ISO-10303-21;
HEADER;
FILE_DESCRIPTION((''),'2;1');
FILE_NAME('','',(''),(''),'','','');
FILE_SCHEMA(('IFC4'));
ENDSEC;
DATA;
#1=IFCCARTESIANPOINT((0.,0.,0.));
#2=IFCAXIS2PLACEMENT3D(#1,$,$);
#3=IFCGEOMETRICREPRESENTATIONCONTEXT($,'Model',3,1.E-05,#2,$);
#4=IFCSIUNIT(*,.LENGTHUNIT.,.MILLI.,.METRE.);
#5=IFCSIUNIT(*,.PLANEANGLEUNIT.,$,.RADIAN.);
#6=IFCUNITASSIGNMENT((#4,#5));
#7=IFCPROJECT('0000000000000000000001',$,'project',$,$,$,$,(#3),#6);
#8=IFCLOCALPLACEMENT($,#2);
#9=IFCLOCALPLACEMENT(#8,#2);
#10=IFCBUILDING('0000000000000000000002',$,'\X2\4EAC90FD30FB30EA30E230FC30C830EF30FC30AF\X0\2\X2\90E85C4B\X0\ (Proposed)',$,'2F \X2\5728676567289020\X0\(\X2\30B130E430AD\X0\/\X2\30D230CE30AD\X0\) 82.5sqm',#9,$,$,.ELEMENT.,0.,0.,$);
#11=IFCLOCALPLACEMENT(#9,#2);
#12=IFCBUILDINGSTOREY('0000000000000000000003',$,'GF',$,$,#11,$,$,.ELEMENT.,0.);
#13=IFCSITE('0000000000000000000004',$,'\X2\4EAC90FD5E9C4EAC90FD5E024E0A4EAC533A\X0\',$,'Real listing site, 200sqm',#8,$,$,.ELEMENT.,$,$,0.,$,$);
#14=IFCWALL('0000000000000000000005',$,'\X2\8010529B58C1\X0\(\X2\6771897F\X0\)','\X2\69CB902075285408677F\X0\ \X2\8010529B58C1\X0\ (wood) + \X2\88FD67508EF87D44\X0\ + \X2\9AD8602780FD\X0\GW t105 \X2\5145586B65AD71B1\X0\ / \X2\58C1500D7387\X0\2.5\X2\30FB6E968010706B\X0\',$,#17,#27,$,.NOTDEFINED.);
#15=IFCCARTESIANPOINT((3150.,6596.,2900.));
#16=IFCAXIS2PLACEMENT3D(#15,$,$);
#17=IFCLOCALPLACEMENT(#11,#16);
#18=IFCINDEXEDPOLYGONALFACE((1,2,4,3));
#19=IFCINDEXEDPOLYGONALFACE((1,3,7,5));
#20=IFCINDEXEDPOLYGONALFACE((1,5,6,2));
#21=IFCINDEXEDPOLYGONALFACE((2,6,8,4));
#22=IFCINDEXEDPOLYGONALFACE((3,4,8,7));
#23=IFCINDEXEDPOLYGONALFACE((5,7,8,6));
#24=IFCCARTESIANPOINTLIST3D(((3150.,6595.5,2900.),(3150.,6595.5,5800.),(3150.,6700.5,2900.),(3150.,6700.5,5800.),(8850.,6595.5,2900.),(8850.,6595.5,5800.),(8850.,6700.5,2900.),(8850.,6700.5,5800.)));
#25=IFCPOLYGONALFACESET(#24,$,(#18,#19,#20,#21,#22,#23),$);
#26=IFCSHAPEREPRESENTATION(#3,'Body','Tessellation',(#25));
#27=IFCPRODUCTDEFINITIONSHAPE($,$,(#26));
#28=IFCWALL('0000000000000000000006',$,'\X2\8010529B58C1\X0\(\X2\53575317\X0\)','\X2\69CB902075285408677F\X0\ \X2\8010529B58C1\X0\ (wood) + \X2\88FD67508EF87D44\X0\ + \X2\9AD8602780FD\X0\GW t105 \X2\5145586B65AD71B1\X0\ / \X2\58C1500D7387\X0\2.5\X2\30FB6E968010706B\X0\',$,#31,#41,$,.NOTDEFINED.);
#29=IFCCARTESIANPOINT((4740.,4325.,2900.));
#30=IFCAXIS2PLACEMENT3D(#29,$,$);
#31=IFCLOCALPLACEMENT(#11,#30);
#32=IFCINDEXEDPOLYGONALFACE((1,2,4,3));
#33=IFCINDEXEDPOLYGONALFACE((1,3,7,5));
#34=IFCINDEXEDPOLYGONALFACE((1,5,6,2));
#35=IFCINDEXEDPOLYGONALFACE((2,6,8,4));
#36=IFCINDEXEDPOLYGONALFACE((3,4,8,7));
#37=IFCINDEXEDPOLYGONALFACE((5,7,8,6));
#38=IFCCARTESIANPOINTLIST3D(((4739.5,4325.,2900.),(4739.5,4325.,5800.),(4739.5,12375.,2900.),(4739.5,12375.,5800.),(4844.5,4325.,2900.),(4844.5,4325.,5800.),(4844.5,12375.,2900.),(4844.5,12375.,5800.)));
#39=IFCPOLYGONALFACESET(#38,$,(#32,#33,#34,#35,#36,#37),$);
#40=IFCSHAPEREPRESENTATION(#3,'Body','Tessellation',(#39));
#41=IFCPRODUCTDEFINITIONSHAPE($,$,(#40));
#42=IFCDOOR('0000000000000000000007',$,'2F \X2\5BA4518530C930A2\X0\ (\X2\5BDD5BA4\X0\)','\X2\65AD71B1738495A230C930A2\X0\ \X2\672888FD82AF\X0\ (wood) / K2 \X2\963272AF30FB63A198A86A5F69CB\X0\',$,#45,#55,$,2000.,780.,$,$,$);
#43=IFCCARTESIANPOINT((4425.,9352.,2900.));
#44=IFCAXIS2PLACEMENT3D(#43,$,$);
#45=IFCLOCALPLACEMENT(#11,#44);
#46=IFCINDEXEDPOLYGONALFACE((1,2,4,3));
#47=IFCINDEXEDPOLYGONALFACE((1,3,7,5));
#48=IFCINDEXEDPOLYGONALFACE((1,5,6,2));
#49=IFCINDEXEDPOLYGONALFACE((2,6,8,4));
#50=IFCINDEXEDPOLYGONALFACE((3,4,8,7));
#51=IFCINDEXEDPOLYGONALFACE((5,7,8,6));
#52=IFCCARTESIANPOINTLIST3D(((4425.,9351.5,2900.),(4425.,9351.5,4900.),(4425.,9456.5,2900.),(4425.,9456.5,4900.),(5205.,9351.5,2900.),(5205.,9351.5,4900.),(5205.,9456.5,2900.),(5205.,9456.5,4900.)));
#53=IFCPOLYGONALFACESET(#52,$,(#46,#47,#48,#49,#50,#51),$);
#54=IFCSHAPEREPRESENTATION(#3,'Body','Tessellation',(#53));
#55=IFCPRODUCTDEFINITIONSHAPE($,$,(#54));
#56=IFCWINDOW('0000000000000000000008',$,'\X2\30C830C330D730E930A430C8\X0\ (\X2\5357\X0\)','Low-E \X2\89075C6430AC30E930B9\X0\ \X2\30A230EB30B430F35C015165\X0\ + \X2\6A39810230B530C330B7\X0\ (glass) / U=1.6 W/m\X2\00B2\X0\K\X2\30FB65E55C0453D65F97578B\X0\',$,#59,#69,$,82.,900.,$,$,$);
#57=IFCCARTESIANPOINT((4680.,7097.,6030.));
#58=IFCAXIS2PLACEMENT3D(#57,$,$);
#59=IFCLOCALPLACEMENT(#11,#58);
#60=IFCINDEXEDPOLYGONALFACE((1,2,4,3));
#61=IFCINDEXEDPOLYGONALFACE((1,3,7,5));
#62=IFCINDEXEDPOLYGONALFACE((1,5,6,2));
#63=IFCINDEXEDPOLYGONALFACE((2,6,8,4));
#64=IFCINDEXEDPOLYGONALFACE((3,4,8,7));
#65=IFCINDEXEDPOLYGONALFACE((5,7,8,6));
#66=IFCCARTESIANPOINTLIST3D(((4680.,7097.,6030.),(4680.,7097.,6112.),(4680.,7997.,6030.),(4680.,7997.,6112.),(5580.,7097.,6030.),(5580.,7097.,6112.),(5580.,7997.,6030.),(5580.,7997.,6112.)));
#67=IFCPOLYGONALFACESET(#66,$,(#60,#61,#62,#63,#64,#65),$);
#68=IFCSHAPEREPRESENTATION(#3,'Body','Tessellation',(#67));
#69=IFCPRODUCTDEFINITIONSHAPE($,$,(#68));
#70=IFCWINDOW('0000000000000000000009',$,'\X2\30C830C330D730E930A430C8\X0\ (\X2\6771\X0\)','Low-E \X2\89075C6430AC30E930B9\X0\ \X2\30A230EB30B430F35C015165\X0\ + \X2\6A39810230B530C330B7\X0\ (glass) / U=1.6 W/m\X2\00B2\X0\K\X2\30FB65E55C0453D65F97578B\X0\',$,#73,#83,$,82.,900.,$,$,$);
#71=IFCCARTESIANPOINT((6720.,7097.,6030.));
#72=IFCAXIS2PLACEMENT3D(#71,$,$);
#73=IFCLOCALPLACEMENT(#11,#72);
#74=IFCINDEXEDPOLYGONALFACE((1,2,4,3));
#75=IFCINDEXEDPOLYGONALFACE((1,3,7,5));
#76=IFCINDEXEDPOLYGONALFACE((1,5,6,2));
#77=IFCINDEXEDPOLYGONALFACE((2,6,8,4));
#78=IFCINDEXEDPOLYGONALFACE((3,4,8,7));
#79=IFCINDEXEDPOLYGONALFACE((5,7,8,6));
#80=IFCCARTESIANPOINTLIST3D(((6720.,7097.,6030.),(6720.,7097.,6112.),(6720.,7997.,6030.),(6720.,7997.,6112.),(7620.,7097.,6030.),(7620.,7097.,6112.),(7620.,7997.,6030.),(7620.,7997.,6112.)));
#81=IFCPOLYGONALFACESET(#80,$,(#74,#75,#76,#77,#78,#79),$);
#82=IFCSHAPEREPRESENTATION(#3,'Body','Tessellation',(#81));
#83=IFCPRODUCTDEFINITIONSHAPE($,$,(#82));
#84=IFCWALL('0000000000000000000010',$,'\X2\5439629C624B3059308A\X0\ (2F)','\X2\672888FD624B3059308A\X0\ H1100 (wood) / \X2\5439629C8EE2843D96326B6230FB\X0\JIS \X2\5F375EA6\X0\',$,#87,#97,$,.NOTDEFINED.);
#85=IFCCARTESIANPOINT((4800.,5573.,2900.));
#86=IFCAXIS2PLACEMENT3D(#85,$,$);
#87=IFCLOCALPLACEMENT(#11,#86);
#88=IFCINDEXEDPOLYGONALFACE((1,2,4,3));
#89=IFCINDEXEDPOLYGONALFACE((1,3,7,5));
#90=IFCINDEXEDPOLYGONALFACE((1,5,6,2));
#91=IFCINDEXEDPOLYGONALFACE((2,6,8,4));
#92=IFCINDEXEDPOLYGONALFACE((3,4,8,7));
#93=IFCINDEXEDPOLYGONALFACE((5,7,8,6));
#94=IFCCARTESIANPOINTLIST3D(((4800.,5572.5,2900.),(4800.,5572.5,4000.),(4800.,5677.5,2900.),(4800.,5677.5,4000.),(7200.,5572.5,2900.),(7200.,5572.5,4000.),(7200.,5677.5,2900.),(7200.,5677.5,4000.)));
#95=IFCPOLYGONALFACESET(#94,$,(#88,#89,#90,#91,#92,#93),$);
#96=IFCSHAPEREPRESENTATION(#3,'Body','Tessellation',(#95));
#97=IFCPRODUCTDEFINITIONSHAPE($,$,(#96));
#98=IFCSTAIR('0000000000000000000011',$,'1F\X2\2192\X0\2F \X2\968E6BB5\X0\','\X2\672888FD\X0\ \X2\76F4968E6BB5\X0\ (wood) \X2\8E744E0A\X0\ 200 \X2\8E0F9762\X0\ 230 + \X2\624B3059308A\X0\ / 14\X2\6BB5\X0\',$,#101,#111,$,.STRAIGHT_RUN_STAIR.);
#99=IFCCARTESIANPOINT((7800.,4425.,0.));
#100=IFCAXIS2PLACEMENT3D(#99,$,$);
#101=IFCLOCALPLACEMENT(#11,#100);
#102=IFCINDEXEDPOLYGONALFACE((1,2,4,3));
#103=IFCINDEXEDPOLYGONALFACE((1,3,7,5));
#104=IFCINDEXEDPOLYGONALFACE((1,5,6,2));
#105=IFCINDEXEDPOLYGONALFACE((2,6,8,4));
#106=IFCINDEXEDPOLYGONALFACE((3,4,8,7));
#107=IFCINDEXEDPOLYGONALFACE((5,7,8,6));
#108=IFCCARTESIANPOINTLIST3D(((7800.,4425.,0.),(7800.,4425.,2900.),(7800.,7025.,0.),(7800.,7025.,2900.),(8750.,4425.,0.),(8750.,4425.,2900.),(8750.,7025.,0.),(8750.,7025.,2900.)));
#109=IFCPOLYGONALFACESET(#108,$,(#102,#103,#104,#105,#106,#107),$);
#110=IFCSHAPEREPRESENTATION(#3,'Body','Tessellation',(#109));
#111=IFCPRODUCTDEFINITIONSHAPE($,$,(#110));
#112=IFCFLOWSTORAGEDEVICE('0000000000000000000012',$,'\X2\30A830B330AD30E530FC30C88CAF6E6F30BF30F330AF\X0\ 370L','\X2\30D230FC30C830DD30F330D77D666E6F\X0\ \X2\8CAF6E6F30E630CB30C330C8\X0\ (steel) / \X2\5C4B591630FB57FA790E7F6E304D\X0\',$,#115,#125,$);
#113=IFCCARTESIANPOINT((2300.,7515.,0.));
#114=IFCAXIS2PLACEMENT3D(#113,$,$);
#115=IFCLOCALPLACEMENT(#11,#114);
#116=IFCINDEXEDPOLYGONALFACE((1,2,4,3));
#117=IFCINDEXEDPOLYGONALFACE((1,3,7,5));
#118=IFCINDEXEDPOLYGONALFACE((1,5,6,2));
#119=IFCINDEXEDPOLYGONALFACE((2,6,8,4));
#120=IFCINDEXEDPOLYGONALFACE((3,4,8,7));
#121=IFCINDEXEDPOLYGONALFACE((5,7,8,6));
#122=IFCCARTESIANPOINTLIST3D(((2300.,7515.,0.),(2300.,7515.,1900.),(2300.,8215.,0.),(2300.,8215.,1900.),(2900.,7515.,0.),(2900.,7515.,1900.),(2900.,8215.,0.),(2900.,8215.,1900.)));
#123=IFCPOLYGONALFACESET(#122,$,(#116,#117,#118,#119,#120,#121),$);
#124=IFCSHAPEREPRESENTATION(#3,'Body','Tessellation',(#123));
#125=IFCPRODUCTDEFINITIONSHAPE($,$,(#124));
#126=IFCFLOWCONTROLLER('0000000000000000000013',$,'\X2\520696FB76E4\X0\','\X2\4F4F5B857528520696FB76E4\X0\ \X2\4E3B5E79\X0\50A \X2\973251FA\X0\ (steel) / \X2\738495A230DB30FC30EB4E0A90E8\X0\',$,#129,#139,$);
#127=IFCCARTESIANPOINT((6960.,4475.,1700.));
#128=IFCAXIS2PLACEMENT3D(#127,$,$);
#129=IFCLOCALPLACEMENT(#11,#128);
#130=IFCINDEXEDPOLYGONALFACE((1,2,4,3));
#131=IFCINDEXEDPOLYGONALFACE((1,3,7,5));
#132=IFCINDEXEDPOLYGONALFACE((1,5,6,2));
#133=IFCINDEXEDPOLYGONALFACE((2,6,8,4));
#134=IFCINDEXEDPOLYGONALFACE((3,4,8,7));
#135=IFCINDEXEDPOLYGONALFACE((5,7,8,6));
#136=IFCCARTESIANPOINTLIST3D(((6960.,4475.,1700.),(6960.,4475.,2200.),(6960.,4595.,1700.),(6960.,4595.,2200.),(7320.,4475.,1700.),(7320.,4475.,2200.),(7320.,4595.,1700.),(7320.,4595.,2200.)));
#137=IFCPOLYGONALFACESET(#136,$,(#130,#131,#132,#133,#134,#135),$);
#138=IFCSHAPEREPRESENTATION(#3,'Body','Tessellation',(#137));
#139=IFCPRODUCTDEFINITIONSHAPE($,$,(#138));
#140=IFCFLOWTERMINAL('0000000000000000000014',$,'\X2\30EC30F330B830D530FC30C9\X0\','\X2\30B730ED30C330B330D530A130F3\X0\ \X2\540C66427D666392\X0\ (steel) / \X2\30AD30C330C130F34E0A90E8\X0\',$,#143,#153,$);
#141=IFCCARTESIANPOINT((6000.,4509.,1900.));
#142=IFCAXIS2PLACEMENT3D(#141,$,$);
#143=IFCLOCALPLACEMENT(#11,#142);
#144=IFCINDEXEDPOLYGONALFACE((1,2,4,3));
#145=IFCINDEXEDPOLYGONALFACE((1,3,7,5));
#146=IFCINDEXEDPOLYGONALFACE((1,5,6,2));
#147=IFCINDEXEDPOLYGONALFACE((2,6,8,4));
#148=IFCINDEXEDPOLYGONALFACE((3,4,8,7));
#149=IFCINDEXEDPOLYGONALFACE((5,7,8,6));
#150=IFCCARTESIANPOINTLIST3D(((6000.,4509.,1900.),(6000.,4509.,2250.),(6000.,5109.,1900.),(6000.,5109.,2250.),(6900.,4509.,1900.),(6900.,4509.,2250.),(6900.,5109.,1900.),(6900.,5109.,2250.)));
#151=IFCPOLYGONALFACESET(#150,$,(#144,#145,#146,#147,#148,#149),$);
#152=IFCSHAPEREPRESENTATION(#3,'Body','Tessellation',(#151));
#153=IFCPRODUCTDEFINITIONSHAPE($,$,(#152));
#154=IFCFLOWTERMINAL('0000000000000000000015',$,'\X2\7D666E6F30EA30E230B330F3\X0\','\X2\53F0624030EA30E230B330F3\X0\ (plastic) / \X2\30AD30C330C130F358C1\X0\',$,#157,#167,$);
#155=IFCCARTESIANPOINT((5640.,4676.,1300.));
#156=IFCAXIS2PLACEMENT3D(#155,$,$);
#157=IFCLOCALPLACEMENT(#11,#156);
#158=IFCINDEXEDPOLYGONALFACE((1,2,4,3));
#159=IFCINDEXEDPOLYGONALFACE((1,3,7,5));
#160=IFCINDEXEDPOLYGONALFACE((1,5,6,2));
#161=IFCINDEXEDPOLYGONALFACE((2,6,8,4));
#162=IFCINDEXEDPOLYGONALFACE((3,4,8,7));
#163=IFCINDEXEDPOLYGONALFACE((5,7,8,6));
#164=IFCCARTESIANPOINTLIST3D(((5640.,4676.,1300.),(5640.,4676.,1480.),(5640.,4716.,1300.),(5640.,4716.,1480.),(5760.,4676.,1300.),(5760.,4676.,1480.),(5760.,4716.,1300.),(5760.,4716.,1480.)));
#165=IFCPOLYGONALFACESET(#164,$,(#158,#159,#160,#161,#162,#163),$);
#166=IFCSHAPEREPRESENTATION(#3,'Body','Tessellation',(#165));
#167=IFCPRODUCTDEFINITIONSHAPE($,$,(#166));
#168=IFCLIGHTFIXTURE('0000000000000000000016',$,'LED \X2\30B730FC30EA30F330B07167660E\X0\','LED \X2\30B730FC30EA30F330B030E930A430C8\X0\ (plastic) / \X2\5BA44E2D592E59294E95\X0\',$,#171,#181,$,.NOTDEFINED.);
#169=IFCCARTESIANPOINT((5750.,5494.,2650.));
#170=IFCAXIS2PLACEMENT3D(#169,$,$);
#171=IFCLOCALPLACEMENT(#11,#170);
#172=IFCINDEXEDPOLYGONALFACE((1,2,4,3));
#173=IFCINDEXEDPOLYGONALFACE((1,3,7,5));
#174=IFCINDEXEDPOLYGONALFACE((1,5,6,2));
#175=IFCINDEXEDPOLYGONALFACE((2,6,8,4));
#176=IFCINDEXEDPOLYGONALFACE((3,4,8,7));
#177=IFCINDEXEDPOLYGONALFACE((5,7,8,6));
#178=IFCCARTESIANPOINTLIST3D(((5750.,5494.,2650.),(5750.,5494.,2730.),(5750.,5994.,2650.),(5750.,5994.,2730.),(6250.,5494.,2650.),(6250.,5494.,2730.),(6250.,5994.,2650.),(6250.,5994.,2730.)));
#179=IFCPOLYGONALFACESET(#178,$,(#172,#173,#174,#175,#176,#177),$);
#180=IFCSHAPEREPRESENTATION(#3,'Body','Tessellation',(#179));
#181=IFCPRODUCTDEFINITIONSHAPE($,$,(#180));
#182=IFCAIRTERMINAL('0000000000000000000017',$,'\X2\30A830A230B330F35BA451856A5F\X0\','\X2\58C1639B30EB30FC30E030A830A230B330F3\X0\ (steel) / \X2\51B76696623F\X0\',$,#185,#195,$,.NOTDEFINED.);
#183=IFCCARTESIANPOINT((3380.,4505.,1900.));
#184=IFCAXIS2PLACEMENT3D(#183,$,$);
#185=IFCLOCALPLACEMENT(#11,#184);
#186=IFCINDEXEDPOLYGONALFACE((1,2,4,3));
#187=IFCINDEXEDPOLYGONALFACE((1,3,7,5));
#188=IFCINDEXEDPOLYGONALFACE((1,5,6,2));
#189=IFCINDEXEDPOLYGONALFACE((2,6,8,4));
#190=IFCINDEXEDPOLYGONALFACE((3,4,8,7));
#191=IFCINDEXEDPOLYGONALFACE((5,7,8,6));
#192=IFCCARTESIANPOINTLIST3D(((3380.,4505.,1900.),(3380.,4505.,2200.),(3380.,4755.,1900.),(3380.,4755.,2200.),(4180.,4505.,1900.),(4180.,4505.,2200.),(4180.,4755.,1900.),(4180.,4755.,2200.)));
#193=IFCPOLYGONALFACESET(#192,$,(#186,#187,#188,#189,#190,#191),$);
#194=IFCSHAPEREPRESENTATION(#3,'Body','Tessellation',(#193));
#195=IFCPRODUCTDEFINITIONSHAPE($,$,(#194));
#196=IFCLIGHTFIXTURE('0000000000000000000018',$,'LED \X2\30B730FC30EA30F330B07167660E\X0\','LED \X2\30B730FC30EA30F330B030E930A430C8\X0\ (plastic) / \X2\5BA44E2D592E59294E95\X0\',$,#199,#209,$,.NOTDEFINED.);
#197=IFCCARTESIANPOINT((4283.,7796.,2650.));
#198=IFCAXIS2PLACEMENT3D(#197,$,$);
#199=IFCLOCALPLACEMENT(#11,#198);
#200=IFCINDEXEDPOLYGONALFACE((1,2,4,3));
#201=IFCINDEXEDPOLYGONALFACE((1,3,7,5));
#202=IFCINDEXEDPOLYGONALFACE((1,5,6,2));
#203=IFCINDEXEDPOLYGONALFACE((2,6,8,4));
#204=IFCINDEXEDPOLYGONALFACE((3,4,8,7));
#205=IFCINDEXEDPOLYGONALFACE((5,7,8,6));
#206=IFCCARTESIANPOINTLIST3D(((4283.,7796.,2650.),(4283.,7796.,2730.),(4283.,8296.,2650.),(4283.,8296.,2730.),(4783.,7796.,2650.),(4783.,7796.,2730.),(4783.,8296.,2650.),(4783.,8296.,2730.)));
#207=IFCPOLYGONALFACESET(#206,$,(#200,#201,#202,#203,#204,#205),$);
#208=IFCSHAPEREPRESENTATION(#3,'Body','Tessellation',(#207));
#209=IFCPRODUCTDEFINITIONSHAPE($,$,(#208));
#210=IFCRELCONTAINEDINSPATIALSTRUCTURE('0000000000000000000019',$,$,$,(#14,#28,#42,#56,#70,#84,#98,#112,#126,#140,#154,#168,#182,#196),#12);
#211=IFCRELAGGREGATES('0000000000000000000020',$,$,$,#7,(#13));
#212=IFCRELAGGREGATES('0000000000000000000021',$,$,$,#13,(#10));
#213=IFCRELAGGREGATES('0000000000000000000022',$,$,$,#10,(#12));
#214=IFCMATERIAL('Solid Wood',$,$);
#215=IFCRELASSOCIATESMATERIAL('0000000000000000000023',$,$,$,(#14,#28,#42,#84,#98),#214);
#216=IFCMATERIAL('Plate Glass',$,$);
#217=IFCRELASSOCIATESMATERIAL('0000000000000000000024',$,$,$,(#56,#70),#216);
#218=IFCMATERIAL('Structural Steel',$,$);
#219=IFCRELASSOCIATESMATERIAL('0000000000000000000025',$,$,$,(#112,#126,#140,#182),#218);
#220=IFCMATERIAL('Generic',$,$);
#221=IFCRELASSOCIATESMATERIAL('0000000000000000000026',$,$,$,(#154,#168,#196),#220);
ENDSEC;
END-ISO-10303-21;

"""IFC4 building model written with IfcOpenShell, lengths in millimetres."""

from ifc_helpers import new_model, si_unit, frame, frame_2d, origin, place, context, project, spatial, rectangle, extrude, material, element, fill, save


model = new_model("IFC4")

# Units and contexts
model_context = context("Model", 3, precision=1e-05, world=origin())
ifc_project = project(units=[si_unit("LENGTHUNIT", "METRE", prefix="MILLI"), si_unit("PLANEANGLEUNIT", "RADIAN")], contexts=[model_context])

# Site, building, storey
site_placement = place(None, origin())
site = spatial("IfcSite", under=ifc_project, at=site_placement, Name="京都府京都市上京区", ObjectType="Real listing site, 200sqm", CompositionType="ELEMENT", RefElevation=0.0)
building_placement = place(site_placement, origin())
building = spatial("IfcBuilding", under=site, at=building_placement, Name="京都・リモートワーク2部屋 (Proposed)", ObjectType="2F 在来木造(ケヤキ/ヒノキ) 82.5sqm", CompositionType="ELEMENT", ElevationOfRefHeight=0.0, ElevationOfTerrain=0.0)
storey_placement = place(building_placement, origin())
storey = spatial("IfcBuildingStorey", under=building, at=storey_placement, Name="GF", CompositionType="ELEMENT", Elevation=0.0)

# Shared definitions
ifc_material_1 = material(Name="Solid Wood")

# Wall
wall_1_placement = place(storey_placement, frame((3150.0, 6596.0, 2900.0)))
element("IfcWall", 1, at=wall_1_placement, inside=storey, material=ifc_material_1, Name="耐力壁(東西)", Description="構造用合板 耐力壁 (wood) + 製材軸組 + 高性能GW t105 充填断熱 / 壁倍率2.5・準耐火", PredefinedType="NOTDEFINED", context=model_context, shape_type="SweptSolid", body=[
    extrude(rectangle(XDim=5700.0, YDim=105.0, at=frame_2d((2850.0, 52.0))), frame((3150.0, 6596.0, 2900.0)), (0.0, 0.0, 1.0), 2900.0),
])

# Wall, opening, door
wall_2_placement = place(storey_placement, frame((4740.0, 4325.0, 2900.0)))
wall_2 = element("IfcWall", 2, at=wall_2_placement, inside=storey, material=ifc_material_1, Name="耐力壁(南北)", Description="構造用合板 耐力壁 (wood) + 製材軸組 + 高性能GW t105 充填断熱 / 壁倍率2.5・準耐火", PredefinedType="NOTDEFINED", context=model_context, shape_type="SweptSolid", body=[
    extrude(rectangle(XDim=105.0, YDim=8050.0, at=frame_2d((52.0, 4025.0))), frame((4740.0, 4325.0, 2900.0)), (0.0, 0.0, 1.0), 2900.0),
])
opening_placement = place(storey_placement, frame((4425.0, 9352.0, 2900.0)))
opening = element("IfcOpeningElement", 3, at=opening_placement, cuts=wall_2, PredefinedType="NOTDEFINED", context=model_context, shape_type="SweptSolid", body=[
    extrude(rectangle(XDim=780.0, YDim=105.0, at=frame_2d((390.0, 52.0))), frame((4425.0, 9352.0, 2900.0)), (0.0, 0.0, 1.0), 2000.0),
])
door_placement = place(storey_placement, frame((4425.0, 9352.0, 2900.0)))
door = element("IfcDoor", 4, at=door_placement, inside=storey, material=ifc_material_1, Name="2F 室内ドア (寝室)", Description="断熱玄関ドア 木製芯 (wood) / K2 防犯・採風機構", OverallHeight=2000.0, OverallWidth=780.0, context=model_context, shape_type="SweptSolid", body=[
    extrude(rectangle(XDim=780.0, YDim=105.0, at=frame_2d((390.0, 52.0))), frame((4425.0, 9352.0, 2900.0)), (0.0, 0.0, 1.0), 2000.0),
])
fill(opening, door)

# Windows
ifc_material_2 = material(Name="Plate Glass")
window_1_placement = place(storey_placement, frame((4680.0, 7097.0, 6030.0)))
element("IfcWindow", 5, at=window_1_placement, inside=storey, material=ifc_material_2, Name="トップライト (南)", Description="Low-E 複層ガラス アルゴン封入 + 樹脂サッシ (glass) / U=1.6 W/m²K・日射取得型", OverallHeight=82.0, OverallWidth=900.0, context=model_context, shape_type="SweptSolid", body=[
    extrude(rectangle(XDim=900.0, YDim=900.0, at=frame_2d((450.0, 450.0))), frame((4680.0, 7097.0, 6030.0)), (0.0, 0.0, 1.0), 82.0),
])
window_2_placement = place(storey_placement, frame((6720.0, 7097.0, 6030.0)))
element("IfcWindow", 6, at=window_2_placement, inside=storey, material=ifc_material_2, Name="トップライト (東)", Description="Low-E 複層ガラス アルゴン封入 + 樹脂サッシ (glass) / U=1.6 W/m²K・日射取得型", OverallHeight=82.0, OverallWidth=900.0, context=model_context, shape_type="SweptSolid", body=[
    extrude(rectangle(XDim=900.0, YDim=900.0, at=frame_2d((450.0, 450.0))), frame((6720.0, 7097.0, 6030.0)), (0.0, 0.0, 1.0), 82.0),
])

# Wall
wall_3_placement = place(storey_placement, frame((4800.0, 5573.0, 2900.0)))
element("IfcWall", 7, at=wall_3_placement, inside=storey, material=ifc_material_1, Name="吹抜手すり (2F)", Description="木製手すり H1100 (wood) / 吹抜転落防止・JIS 強度", PredefinedType="NOTDEFINED", context=model_context, shape_type="SweptSolid", body=[
    extrude(rectangle(XDim=2400.0, YDim=105.0, at=frame_2d((1200.0, 52.0))), frame((4800.0, 5573.0, 2900.0)), (0.0, 0.0, 1.0), 1100.0),
])

# Stair
stair_placement = place(storey_placement, frame((7800.0, 4425.0, 0.0)))
element("IfcStair", 8, at=stair_placement, inside=storey, material=ifc_material_1, Name="1F→2F 階段", Description="木製 直階段 (wood) 蹴上 200 踏面 230 + 手すり / 14段", PredefinedType="STRAIGHT_RUN_STAIR", context=model_context, shape_type="SweptSolid", body=[
    extrude(rectangle(XDim=950.0, YDim=2600.0, at=frame_2d((475.0, 1300.0))), frame((7800.0, 4425.0, 0.0)), (0.0, 0.0, 1.0), 2900.0),
])

# Flow storage device
ifc_material_3 = material(Name="Structural Steel")
flow_storage_device_placement = place(storey_placement, frame((2300.0, 7515.0, 0.0)))
element("IfcFlowStorageDevice", 9, at=flow_storage_device_placement, inside=storey, material=ifc_material_3, Name="エコキュート貯湯タンク 370L", Description="ヒートポンプ給湯 貯湯ユニット (steel) / 屋外・基礎置き", context=model_context, shape_type="SweptSolid", body=[
    extrude(rectangle(XDim=600.0, YDim=700.0, at=frame_2d((300.0, 350.0))), frame((2300.0, 7515.0, 0.0)), (0.0, 0.0, 1.0), 1900.0),
])

# Flow controller
flow_controller_placement = place(storey_placement, frame((6960.0, 4475.0, 1700.0)))
element("IfcFlowController", 10, at=flow_controller_placement, inside=storey, material=ifc_material_3, Name="分電盤", Description="住宅用分電盤 主幹50A 露出 (steel) / 玄関ホール上部", context=model_context, shape_type="SweptSolid", body=[
    extrude(rectangle(XDim=360.0, YDim=120.0, at=frame_2d((180.0, 60.0))), frame((6960.0, 4475.0, 1700.0)), (0.0, 0.0, 1.0), 500.0),
])

# Flow terminals
flow_terminal_1_placement = place(storey_placement, frame((6000.0, 4509.0, 1900.0)))
element("IfcFlowTerminal", 11, at=flow_terminal_1_placement, inside=storey, material=ifc_material_3, Name="レンジフード", Description="シロッコファン 同時給排 (steel) / キッチン上部", context=model_context, shape_type="SweptSolid", body=[
    extrude(rectangle(XDim=900.0, YDim=600.0, at=frame_2d((450.0, 300.0))), frame((6000.0, 4509.0, 1900.0)), (0.0, 0.0, 1.0), 350.0),
])
ifc_material_4 = material(Name="Generic")
flow_terminal_2_placement = place(storey_placement, frame((5640.0, 4676.0, 1300.0)))
element("IfcFlowTerminal", 12, at=flow_terminal_2_placement, inside=storey, material=ifc_material_4, Name="給湯リモコン", Description="台所リモコン (plastic) / キッチン壁", context=model_context, shape_type="SweptSolid", body=[
    extrude(rectangle(XDim=120.0, YDim=40.0, at=frame_2d((60.0, 20.0))), frame((5640.0, 4676.0, 1300.0)), (0.0, 0.0, 1.0), 180.0),
])

# Light fixture
light_fixture_1_placement = place(storey_placement, frame((5750.0, 5494.0, 2650.0)))
element("IfcLightFixture", 13, at=light_fixture_1_placement, inside=storey, material=ifc_material_4, Name="LED シーリング照明", Description="LED シーリングライト (plastic) / 室中央天井", PredefinedType="NOTDEFINED", context=model_context, shape_type="SweptSolid", body=[
    extrude(rectangle(XDim=500.0, YDim=500.0, at=frame_2d((250.0, 250.0))), frame((5750.0, 5494.0, 2650.0)), (0.0, 0.0, 1.0), 80.0),
])

# Air terminal
air_terminal_1_placement = place(storey_placement, frame((3380.0, 4505.0, 1900.0)))
element("IfcAirTerminal", 14, at=air_terminal_1_placement, inside=storey, material=ifc_material_3, Name="エアコン室内機", Description="壁掛ルームエアコン (steel) / 冷暖房", PredefinedType="NOTDEFINED", context=model_context, shape_type="SweptSolid", body=[
    extrude(rectangle(XDim=800.0, YDim=250.0, at=frame_2d((400.0, 125.0))), frame((3380.0, 4505.0, 1900.0)), (0.0, 0.0, 1.0), 300.0),
])

# Light fixture
light_fixture_2_placement = place(storey_placement, frame((4283.0, 7796.0, 2650.0)))
element("IfcLightFixture", 15, at=light_fixture_2_placement, inside=storey, material=ifc_material_4, Name="LED シーリング照明", Description="LED シーリングライト (plastic) / 室中央天井", PredefinedType="NOTDEFINED", context=model_context, shape_type="SweptSolid", body=[
    extrude(rectangle(XDim=500.0, YDim=500.0, at=frame_2d((250.0, 250.0))), frame((4283.0, 7796.0, 2650.0)), (0.0, 0.0, 1.0), 80.0),
])

save(model, "model.ifc")
